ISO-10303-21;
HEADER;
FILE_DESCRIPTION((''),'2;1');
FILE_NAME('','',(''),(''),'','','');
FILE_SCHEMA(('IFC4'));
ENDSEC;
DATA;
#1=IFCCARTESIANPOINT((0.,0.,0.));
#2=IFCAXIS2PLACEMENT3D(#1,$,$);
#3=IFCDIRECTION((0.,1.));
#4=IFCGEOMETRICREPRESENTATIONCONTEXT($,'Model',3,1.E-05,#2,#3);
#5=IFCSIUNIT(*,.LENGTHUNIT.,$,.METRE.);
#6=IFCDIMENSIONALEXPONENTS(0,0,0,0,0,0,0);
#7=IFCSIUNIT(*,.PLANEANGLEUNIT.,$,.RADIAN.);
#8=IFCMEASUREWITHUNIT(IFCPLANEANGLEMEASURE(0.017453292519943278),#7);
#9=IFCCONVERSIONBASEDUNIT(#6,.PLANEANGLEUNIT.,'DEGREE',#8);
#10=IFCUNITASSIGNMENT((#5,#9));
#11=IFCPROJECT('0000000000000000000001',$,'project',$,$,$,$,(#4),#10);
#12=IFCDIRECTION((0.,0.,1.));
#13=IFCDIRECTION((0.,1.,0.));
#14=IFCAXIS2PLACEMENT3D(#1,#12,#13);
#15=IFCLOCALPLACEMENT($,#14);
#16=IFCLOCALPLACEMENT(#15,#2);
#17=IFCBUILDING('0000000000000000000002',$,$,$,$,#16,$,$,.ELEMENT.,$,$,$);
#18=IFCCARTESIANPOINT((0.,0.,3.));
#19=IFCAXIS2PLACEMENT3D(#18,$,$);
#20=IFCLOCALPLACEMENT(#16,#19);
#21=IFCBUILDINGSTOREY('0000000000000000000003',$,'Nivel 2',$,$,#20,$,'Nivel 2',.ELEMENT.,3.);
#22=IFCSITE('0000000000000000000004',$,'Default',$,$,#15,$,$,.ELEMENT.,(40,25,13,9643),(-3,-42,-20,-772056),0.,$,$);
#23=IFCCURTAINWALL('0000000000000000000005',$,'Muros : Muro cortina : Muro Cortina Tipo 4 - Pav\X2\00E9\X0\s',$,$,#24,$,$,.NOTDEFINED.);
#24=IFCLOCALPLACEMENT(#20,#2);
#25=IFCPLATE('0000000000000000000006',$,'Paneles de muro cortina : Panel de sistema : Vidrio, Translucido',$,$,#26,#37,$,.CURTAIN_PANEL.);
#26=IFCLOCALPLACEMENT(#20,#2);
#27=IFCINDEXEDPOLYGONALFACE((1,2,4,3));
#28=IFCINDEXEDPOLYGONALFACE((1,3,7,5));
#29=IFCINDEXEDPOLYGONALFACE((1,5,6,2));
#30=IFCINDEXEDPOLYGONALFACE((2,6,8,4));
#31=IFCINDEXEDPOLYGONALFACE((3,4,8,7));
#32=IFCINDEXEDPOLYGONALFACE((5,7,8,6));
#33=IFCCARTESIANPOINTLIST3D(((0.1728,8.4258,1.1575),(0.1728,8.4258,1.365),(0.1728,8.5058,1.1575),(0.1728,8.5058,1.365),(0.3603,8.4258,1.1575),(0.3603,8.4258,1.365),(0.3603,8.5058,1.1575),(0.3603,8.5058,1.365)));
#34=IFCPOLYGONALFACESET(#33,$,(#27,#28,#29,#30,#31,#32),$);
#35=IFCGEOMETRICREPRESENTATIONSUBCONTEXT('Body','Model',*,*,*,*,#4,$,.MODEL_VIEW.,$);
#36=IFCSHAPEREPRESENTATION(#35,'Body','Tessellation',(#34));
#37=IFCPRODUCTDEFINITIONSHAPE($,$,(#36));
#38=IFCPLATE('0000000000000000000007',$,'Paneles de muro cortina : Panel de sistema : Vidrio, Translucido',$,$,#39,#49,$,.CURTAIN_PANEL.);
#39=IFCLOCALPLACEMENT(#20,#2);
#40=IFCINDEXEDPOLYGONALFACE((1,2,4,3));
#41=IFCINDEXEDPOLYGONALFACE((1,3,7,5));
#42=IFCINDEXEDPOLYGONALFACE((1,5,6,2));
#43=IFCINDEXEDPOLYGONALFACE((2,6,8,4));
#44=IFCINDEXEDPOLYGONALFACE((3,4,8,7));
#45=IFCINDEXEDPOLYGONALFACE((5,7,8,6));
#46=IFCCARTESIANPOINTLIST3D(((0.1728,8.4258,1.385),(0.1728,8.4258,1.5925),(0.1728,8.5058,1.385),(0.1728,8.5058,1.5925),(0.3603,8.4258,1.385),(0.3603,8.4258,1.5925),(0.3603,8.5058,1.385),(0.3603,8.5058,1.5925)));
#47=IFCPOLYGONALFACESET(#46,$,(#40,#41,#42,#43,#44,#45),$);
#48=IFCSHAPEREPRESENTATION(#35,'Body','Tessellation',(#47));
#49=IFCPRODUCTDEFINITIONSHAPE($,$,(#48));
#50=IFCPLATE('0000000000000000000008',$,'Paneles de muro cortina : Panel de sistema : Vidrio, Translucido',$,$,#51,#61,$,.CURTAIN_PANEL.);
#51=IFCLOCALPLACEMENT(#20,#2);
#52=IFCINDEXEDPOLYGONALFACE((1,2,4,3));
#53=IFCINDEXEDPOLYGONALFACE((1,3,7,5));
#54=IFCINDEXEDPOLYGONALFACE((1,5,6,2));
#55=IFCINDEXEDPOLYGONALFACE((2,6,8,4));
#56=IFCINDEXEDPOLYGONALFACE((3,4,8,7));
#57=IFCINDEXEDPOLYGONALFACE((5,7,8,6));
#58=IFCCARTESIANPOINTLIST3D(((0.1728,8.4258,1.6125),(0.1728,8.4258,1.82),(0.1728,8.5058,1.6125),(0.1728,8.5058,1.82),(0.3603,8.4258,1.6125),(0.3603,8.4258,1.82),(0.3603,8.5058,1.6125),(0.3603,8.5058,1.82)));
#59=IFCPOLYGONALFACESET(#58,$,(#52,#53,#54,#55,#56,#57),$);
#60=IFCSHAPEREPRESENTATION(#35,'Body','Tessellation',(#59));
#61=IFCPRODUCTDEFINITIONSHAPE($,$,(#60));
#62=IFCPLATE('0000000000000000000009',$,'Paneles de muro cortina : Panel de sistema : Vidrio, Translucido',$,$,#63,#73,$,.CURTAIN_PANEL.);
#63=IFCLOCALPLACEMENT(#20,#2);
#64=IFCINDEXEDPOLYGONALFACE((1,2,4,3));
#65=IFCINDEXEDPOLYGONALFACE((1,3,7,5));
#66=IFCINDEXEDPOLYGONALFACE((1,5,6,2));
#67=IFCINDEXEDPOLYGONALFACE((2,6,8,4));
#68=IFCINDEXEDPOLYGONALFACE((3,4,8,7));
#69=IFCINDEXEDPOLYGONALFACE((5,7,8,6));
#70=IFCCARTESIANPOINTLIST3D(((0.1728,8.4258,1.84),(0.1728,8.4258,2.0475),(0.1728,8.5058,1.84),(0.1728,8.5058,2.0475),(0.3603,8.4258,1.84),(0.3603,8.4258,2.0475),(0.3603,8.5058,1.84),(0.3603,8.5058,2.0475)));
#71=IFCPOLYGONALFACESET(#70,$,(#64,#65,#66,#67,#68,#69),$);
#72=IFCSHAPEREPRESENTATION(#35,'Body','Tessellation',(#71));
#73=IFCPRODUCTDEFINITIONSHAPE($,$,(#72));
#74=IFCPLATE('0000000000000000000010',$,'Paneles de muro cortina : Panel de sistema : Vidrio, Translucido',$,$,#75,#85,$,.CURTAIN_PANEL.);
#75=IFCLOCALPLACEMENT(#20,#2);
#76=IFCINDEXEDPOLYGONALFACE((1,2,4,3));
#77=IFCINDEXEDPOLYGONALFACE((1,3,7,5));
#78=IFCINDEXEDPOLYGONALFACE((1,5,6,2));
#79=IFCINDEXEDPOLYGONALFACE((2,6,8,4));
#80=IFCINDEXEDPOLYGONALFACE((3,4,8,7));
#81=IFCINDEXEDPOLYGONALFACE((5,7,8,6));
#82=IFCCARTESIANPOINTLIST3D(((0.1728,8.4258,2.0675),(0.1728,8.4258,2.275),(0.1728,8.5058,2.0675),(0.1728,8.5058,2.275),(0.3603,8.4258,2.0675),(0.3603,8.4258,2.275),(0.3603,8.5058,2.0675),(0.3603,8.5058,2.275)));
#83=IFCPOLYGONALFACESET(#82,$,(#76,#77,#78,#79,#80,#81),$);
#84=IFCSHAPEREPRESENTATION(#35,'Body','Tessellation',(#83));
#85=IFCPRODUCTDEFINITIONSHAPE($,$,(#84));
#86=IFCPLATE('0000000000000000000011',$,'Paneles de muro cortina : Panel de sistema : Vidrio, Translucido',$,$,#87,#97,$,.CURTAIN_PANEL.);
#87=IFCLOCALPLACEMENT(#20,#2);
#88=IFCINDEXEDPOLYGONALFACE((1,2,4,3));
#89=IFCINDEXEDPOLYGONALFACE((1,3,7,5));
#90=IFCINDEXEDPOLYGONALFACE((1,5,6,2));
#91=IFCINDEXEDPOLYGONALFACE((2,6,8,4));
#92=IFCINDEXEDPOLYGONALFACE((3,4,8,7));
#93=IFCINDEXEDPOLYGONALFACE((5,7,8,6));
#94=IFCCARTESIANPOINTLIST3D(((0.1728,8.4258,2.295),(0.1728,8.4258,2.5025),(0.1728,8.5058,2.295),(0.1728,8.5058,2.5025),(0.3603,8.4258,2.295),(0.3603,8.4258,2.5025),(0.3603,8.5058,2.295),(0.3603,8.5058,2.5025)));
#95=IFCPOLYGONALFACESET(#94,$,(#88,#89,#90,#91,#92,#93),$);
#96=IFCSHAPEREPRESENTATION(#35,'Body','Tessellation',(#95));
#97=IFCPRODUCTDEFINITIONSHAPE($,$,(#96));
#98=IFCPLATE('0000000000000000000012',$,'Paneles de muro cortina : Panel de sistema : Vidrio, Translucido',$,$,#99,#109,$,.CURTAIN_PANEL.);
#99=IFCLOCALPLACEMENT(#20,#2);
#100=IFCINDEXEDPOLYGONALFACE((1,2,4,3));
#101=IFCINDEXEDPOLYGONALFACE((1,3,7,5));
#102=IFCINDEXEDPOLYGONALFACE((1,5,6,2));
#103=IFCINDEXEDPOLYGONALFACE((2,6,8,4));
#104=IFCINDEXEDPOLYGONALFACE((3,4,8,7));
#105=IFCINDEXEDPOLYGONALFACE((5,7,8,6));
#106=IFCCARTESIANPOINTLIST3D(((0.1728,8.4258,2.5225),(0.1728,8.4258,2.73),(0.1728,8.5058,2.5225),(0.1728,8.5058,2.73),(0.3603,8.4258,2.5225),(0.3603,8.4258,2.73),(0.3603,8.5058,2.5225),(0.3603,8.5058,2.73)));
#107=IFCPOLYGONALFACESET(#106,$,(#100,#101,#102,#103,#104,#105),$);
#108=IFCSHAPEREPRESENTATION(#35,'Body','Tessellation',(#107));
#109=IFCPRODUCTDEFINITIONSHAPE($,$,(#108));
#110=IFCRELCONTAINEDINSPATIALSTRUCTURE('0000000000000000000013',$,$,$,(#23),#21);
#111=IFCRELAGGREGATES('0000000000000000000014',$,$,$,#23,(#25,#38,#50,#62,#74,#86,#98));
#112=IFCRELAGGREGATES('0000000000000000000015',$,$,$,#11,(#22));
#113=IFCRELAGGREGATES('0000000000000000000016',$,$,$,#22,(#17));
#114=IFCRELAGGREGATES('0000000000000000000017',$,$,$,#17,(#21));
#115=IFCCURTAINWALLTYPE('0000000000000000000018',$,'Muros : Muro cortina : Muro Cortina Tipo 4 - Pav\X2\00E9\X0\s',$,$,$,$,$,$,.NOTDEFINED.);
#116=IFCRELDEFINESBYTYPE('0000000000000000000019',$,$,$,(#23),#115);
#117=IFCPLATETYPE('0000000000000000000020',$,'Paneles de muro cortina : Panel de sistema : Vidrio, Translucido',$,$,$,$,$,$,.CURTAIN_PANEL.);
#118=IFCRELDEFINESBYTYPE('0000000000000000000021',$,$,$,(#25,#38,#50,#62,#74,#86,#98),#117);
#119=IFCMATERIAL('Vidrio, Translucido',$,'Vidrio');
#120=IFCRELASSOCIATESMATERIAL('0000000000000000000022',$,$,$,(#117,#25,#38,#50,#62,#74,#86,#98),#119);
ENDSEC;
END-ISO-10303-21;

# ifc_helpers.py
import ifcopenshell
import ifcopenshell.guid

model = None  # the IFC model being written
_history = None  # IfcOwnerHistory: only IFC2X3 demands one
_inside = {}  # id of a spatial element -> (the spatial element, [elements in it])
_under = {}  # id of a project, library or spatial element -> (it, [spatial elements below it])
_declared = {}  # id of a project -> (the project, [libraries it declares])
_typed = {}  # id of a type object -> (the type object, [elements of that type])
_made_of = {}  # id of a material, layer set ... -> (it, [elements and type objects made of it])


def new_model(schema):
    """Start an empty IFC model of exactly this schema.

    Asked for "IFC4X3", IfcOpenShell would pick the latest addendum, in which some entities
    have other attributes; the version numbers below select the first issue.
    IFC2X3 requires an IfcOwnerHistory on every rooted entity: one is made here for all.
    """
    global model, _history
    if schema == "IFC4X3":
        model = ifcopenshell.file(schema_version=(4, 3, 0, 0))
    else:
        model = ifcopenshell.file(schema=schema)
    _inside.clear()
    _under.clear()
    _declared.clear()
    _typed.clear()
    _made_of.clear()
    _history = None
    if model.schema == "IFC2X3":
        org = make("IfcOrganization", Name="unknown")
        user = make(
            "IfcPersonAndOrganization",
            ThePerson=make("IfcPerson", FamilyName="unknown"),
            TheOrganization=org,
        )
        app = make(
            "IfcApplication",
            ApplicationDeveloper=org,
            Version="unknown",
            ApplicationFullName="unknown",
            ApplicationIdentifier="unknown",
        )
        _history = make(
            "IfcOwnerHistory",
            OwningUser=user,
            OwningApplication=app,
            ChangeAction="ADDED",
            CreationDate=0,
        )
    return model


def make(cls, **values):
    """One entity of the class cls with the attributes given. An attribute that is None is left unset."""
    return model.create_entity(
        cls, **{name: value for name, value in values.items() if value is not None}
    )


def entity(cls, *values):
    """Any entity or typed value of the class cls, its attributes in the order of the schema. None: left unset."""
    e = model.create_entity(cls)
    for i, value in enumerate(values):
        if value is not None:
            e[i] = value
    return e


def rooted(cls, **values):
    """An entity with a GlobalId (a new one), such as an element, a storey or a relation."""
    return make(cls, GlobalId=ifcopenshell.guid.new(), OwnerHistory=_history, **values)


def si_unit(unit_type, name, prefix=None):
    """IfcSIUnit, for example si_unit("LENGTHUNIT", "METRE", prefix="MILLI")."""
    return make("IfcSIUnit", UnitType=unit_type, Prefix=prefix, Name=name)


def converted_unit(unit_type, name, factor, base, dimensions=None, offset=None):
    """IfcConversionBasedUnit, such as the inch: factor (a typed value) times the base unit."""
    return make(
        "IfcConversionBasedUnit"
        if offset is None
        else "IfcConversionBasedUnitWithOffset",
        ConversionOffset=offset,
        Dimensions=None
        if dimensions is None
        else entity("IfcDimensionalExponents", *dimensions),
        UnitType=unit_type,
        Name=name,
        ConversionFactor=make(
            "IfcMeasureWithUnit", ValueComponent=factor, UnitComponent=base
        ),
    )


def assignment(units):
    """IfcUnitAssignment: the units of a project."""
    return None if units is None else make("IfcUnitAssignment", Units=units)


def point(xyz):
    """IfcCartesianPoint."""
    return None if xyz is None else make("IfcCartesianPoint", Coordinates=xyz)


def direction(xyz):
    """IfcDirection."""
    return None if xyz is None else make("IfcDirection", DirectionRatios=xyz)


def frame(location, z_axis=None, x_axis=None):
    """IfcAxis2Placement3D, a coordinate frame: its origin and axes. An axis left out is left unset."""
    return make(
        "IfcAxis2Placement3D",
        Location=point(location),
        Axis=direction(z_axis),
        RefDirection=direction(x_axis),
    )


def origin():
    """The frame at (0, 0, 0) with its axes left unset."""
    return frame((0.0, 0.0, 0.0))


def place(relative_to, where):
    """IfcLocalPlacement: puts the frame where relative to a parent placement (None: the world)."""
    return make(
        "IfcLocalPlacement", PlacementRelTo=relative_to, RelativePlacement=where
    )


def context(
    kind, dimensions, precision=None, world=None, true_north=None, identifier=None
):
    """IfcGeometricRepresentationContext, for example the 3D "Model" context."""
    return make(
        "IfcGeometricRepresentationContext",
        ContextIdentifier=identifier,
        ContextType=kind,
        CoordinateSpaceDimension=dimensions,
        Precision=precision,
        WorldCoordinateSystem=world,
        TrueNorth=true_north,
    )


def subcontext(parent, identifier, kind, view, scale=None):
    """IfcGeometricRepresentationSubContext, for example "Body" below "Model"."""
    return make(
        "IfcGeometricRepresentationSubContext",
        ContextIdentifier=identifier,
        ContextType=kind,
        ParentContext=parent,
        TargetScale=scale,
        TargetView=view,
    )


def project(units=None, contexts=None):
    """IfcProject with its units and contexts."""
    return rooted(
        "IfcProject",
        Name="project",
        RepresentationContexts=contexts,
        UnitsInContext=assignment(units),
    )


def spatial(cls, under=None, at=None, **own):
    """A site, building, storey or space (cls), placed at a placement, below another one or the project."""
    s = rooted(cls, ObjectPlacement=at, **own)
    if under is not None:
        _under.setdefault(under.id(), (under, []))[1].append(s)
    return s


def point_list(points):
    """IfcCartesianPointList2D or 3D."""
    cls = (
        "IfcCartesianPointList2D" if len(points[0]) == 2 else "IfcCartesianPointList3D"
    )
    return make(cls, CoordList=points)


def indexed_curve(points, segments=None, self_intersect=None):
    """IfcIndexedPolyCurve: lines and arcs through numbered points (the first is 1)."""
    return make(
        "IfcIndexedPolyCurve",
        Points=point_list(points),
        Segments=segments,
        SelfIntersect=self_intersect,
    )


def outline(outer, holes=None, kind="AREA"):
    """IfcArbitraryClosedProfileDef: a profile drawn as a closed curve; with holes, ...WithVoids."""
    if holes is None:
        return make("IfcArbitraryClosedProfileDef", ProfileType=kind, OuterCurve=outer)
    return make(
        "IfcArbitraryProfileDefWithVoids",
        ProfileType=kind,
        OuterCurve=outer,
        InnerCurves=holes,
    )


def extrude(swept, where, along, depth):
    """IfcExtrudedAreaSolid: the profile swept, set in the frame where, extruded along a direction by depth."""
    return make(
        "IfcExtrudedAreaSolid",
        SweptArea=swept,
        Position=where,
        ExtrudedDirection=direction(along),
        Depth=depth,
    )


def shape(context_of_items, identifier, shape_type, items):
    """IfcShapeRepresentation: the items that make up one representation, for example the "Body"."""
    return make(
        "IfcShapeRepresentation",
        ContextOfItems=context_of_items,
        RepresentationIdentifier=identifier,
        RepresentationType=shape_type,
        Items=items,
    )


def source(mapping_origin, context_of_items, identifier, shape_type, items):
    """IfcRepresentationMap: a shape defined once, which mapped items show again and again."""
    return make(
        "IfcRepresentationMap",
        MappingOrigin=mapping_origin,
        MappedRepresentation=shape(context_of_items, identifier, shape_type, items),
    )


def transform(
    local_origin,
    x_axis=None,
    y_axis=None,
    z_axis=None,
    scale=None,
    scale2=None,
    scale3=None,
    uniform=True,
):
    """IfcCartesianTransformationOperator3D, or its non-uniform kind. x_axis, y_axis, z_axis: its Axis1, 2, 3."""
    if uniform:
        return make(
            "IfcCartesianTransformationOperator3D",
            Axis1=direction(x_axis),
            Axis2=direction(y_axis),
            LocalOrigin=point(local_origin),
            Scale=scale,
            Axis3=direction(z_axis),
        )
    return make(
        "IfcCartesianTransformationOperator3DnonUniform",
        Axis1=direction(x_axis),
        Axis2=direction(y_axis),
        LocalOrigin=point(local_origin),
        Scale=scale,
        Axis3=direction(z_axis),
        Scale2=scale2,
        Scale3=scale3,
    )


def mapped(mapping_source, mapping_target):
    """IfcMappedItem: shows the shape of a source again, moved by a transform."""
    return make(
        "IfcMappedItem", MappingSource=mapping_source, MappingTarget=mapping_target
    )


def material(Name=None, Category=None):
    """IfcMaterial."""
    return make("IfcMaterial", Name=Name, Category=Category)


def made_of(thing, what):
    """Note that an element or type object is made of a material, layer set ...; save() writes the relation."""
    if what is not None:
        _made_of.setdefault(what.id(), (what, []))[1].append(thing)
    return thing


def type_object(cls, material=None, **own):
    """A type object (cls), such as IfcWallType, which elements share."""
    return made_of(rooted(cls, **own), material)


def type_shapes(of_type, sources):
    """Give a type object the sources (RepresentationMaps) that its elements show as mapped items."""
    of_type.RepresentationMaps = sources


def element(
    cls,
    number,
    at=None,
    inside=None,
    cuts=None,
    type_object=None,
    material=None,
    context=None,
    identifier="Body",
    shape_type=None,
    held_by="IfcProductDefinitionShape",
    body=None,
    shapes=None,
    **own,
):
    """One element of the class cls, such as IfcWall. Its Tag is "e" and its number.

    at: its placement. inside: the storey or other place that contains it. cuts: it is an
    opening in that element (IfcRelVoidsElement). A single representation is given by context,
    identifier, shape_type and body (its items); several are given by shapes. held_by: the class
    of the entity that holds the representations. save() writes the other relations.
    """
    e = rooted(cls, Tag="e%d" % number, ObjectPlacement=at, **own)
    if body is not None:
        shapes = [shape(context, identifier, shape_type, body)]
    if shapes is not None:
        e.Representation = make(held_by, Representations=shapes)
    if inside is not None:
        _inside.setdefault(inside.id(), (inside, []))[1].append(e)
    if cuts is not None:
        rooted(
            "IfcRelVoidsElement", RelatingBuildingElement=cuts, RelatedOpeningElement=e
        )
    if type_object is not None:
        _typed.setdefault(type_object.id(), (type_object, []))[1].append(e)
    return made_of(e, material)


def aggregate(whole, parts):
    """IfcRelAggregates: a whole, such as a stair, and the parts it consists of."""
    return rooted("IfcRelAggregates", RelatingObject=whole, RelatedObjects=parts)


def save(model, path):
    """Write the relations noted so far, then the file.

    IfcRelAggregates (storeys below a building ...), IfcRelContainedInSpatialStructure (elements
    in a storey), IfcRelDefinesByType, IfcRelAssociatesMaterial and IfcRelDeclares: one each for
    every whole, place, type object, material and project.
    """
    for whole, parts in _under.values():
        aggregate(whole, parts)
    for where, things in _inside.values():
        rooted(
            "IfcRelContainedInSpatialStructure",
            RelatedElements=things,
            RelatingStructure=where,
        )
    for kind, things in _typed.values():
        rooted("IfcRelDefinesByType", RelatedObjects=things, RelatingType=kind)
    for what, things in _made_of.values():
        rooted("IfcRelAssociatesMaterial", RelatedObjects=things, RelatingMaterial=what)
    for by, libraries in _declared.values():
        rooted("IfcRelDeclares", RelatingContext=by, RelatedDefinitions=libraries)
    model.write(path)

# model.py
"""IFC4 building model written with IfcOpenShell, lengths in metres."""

from ifc_helpers import new_model, entity, si_unit, converted_unit, direction, frame, origin, place, context, subcontext, project, spatial, indexed_curve, outline, extrude, source, transform, mapped, material, type_object, type_shapes, element, aggregate, save


model = new_model("IFC4")

# Units and contexts
model_context = context("Model", 3, precision=1e-05, world=origin(), true_north=direction((0.0, 1.0)))
body_context = subcontext(model_context, "Body", "Model", "MODEL_VIEW")
ifc_project = project(units=[si_unit("LENGTHUNIT", "METRE"), converted_unit("PLANEANGLEUNIT", "DEGREE", entity("IfcPlaneAngleMeasure", 0.017453292519943278), si_unit("PLANEANGLEUNIT", "RADIAN"), dimensions=[0, 0, 0, 0, 0, 0, 0])], contexts=[model_context])

# Site, building, storey
site_placement = place(None, frame((0.0, 0.0, 0.0), z_axis=(0.0, 0.0, 1.0), x_axis=(0.0, 1.0, 0.0)))
site = spatial("IfcSite", under=ifc_project, at=site_placement, Name="Default", CompositionType="ELEMENT", RefLatitude=(40, 25, 13, 9643), RefLongitude=(-3, -42, -20, -772056), RefElevation=0.0)
building_placement = place(site_placement, origin())
building = spatial("IfcBuilding", under=site, at=building_placement, CompositionType="ELEMENT")
storey_placement = place(building_placement, frame((0.0, 0.0, 3.0)))
storey = spatial("IfcBuildingStorey", under=building, at=storey_placement, Name="Nivel 2", LongName="Nivel 2", CompositionType="ELEMENT", Elevation=3.0)

# Curtain wall, plates
curtain_wall_type = type_object("IfcCurtainWallType", Name="Muros : Muro cortina : Muro Cortina Tipo 4 - Pavés", PredefinedType="NOTDEFINED")
curtain_wall_placement = place(storey_placement, frame((0.0, 0.0, -3.0)))
curtain_wall = element("IfcCurtainWall", 1, at=curtain_wall_placement, inside=storey, type_object=curtain_wall_type, Name="Muros : Muro cortina : Muro Cortina Tipo 4 - Pavés", PredefinedType="NOTDEFINED")
ifc_material_1 = material(Name="Vidrio, Translucido", Category="Vidrio")
plate_type = type_object("IfcPlateType", Name="Paneles de muro cortina : Panel de sistema : Vidrio, Translucido", PredefinedType="CURTAIN_PANEL", material=ifc_material_1)
shared_shape_1 = source(origin(), body_context, "Body", "SweptSolid", [
    extrude(outline(indexed_curve([(-0.04, -0.0938), (0.04, -0.0938), (0.04, 0.0938), (-0.04, 0.0938), (-0.04, -0.0938)], self_intersect=False)), frame((0.0, 0.0, 0.0), z_axis=(0.0, 0.0, 1.0), x_axis=(0.0, 1.0, 0.0)), (0.0, 0.0, 1.0), 0.2075),
])
type_shapes(plate_type, [shared_shape_1])
plate_1_placement = place(curtain_wall_placement, frame((0.2665, 8.4658, 4.1575), z_axis=(0.0, 0.0, 1.0), x_axis=(-1.0, 0.0, 0.0)))
plate_1 = element("IfcPlate", 2, at=plate_1_placement, type_object=plate_type, material=ifc_material_1, Name="Paneles de muro cortina : Panel de sistema : Vidrio, Translucido", PredefinedType="CURTAIN_PANEL", context=body_context, shape_type="MappedRepresentation", body=[
    mapped(shared_shape_1, transform((0.0, 0.0, 0.0), scale=1.0)),
])
plate_2_placement = place(curtain_wall_placement, frame((0.2665, 8.4658, 4.385), z_axis=(0.0, 0.0, 1.0), x_axis=(-1.0, 0.0, 0.0)))
plate_2 = element("IfcPlate", 3, at=plate_2_placement, type_object=plate_type, material=ifc_material_1, Name="Paneles de muro cortina : Panel de sistema : Vidrio, Translucido", PredefinedType="CURTAIN_PANEL", context=body_context, shape_type="MappedRepresentation", body=[
    mapped(shared_shape_1, transform((0.0, 0.0, 0.0), scale=1.0)),
])
plate_3_placement = place(curtain_wall_placement, frame((0.2665, 8.4658, 4.6125), z_axis=(0.0, 0.0, 1.0), x_axis=(-1.0, 0.0, 0.0)))
plate_3 = element("IfcPlate", 4, at=plate_3_placement, type_object=plate_type, material=ifc_material_1, Name="Paneles de muro cortina : Panel de sistema : Vidrio, Translucido", PredefinedType="CURTAIN_PANEL", context=body_context, shape_type="MappedRepresentation", body=[
    mapped(shared_shape_1, transform((0.0, 0.0, 0.0), scale=1.0)),
])
plate_4_placement = place(curtain_wall_placement, frame((0.2665, 8.4658, 4.84), z_axis=(0.0, 0.0, 1.0), x_axis=(-1.0, 0.0, 0.0)))
plate_4 = element("IfcPlate", 5, at=plate_4_placement, type_object=plate_type, material=ifc_material_1, Name="Paneles de muro cortina : Panel de sistema : Vidrio, Translucido", PredefinedType="CURTAIN_PANEL", context=body_context, shape_type="MappedRepresentation", body=[
    mapped(shared_shape_1, transform((0.0, 0.0, 0.0), scale=1.0)),
])
plate_5_placement = place(curtain_wall_placement, frame((0.2665, 8.4658, 5.0675), z_axis=(0.0, 0.0, 1.0), x_axis=(-1.0, 0.0, 0.0)))
plate_5 = element("IfcPlate", 6, at=plate_5_placement, type_object=plate_type, material=ifc_material_1, Name="Paneles de muro cortina : Panel de sistema : Vidrio, Translucido", PredefinedType="CURTAIN_PANEL", context=body_context, shape_type="MappedRepresentation", body=[
    mapped(shared_shape_1, transform((0.0, 0.0, 0.0), scale=1.0)),
])
plate_6_placement = place(curtain_wall_placement, frame((0.2665, 8.4658, 5.295), z_axis=(0.0, 0.0, 1.0), x_axis=(-1.0, 0.0, 0.0)))
plate_6 = element("IfcPlate", 7, at=plate_6_placement, type_object=plate_type, material=ifc_material_1, Name="Paneles de muro cortina : Panel de sistema : Vidrio, Translucido", PredefinedType="CURTAIN_PANEL", context=body_context, shape_type="MappedRepresentation", body=[
    mapped(shared_shape_1, transform((0.0, 0.0, 0.0), scale=1.0)),
])
plate_7_placement = place(curtain_wall_placement, frame((0.2665, 8.4658, 5.5225), z_axis=(0.0, 0.0, 1.0), x_axis=(-1.0, 0.0, 0.0)))
plate_7 = element("IfcPlate", 8, at=plate_7_placement, type_object=plate_type, material=ifc_material_1, Name="Paneles de muro cortina : Panel de sistema : Vidrio, Translucido", PredefinedType="CURTAIN_PANEL", context=body_context, shape_type="MappedRepresentation", body=[
    mapped(shared_shape_1, transform((0.0, 0.0, 0.0), scale=1.0)),
])
aggregate(curtain_wall, [plate_1, plate_2, plate_3, plate_4, plate_5, plate_6, plate_7])

save(model, "model.ifc")
